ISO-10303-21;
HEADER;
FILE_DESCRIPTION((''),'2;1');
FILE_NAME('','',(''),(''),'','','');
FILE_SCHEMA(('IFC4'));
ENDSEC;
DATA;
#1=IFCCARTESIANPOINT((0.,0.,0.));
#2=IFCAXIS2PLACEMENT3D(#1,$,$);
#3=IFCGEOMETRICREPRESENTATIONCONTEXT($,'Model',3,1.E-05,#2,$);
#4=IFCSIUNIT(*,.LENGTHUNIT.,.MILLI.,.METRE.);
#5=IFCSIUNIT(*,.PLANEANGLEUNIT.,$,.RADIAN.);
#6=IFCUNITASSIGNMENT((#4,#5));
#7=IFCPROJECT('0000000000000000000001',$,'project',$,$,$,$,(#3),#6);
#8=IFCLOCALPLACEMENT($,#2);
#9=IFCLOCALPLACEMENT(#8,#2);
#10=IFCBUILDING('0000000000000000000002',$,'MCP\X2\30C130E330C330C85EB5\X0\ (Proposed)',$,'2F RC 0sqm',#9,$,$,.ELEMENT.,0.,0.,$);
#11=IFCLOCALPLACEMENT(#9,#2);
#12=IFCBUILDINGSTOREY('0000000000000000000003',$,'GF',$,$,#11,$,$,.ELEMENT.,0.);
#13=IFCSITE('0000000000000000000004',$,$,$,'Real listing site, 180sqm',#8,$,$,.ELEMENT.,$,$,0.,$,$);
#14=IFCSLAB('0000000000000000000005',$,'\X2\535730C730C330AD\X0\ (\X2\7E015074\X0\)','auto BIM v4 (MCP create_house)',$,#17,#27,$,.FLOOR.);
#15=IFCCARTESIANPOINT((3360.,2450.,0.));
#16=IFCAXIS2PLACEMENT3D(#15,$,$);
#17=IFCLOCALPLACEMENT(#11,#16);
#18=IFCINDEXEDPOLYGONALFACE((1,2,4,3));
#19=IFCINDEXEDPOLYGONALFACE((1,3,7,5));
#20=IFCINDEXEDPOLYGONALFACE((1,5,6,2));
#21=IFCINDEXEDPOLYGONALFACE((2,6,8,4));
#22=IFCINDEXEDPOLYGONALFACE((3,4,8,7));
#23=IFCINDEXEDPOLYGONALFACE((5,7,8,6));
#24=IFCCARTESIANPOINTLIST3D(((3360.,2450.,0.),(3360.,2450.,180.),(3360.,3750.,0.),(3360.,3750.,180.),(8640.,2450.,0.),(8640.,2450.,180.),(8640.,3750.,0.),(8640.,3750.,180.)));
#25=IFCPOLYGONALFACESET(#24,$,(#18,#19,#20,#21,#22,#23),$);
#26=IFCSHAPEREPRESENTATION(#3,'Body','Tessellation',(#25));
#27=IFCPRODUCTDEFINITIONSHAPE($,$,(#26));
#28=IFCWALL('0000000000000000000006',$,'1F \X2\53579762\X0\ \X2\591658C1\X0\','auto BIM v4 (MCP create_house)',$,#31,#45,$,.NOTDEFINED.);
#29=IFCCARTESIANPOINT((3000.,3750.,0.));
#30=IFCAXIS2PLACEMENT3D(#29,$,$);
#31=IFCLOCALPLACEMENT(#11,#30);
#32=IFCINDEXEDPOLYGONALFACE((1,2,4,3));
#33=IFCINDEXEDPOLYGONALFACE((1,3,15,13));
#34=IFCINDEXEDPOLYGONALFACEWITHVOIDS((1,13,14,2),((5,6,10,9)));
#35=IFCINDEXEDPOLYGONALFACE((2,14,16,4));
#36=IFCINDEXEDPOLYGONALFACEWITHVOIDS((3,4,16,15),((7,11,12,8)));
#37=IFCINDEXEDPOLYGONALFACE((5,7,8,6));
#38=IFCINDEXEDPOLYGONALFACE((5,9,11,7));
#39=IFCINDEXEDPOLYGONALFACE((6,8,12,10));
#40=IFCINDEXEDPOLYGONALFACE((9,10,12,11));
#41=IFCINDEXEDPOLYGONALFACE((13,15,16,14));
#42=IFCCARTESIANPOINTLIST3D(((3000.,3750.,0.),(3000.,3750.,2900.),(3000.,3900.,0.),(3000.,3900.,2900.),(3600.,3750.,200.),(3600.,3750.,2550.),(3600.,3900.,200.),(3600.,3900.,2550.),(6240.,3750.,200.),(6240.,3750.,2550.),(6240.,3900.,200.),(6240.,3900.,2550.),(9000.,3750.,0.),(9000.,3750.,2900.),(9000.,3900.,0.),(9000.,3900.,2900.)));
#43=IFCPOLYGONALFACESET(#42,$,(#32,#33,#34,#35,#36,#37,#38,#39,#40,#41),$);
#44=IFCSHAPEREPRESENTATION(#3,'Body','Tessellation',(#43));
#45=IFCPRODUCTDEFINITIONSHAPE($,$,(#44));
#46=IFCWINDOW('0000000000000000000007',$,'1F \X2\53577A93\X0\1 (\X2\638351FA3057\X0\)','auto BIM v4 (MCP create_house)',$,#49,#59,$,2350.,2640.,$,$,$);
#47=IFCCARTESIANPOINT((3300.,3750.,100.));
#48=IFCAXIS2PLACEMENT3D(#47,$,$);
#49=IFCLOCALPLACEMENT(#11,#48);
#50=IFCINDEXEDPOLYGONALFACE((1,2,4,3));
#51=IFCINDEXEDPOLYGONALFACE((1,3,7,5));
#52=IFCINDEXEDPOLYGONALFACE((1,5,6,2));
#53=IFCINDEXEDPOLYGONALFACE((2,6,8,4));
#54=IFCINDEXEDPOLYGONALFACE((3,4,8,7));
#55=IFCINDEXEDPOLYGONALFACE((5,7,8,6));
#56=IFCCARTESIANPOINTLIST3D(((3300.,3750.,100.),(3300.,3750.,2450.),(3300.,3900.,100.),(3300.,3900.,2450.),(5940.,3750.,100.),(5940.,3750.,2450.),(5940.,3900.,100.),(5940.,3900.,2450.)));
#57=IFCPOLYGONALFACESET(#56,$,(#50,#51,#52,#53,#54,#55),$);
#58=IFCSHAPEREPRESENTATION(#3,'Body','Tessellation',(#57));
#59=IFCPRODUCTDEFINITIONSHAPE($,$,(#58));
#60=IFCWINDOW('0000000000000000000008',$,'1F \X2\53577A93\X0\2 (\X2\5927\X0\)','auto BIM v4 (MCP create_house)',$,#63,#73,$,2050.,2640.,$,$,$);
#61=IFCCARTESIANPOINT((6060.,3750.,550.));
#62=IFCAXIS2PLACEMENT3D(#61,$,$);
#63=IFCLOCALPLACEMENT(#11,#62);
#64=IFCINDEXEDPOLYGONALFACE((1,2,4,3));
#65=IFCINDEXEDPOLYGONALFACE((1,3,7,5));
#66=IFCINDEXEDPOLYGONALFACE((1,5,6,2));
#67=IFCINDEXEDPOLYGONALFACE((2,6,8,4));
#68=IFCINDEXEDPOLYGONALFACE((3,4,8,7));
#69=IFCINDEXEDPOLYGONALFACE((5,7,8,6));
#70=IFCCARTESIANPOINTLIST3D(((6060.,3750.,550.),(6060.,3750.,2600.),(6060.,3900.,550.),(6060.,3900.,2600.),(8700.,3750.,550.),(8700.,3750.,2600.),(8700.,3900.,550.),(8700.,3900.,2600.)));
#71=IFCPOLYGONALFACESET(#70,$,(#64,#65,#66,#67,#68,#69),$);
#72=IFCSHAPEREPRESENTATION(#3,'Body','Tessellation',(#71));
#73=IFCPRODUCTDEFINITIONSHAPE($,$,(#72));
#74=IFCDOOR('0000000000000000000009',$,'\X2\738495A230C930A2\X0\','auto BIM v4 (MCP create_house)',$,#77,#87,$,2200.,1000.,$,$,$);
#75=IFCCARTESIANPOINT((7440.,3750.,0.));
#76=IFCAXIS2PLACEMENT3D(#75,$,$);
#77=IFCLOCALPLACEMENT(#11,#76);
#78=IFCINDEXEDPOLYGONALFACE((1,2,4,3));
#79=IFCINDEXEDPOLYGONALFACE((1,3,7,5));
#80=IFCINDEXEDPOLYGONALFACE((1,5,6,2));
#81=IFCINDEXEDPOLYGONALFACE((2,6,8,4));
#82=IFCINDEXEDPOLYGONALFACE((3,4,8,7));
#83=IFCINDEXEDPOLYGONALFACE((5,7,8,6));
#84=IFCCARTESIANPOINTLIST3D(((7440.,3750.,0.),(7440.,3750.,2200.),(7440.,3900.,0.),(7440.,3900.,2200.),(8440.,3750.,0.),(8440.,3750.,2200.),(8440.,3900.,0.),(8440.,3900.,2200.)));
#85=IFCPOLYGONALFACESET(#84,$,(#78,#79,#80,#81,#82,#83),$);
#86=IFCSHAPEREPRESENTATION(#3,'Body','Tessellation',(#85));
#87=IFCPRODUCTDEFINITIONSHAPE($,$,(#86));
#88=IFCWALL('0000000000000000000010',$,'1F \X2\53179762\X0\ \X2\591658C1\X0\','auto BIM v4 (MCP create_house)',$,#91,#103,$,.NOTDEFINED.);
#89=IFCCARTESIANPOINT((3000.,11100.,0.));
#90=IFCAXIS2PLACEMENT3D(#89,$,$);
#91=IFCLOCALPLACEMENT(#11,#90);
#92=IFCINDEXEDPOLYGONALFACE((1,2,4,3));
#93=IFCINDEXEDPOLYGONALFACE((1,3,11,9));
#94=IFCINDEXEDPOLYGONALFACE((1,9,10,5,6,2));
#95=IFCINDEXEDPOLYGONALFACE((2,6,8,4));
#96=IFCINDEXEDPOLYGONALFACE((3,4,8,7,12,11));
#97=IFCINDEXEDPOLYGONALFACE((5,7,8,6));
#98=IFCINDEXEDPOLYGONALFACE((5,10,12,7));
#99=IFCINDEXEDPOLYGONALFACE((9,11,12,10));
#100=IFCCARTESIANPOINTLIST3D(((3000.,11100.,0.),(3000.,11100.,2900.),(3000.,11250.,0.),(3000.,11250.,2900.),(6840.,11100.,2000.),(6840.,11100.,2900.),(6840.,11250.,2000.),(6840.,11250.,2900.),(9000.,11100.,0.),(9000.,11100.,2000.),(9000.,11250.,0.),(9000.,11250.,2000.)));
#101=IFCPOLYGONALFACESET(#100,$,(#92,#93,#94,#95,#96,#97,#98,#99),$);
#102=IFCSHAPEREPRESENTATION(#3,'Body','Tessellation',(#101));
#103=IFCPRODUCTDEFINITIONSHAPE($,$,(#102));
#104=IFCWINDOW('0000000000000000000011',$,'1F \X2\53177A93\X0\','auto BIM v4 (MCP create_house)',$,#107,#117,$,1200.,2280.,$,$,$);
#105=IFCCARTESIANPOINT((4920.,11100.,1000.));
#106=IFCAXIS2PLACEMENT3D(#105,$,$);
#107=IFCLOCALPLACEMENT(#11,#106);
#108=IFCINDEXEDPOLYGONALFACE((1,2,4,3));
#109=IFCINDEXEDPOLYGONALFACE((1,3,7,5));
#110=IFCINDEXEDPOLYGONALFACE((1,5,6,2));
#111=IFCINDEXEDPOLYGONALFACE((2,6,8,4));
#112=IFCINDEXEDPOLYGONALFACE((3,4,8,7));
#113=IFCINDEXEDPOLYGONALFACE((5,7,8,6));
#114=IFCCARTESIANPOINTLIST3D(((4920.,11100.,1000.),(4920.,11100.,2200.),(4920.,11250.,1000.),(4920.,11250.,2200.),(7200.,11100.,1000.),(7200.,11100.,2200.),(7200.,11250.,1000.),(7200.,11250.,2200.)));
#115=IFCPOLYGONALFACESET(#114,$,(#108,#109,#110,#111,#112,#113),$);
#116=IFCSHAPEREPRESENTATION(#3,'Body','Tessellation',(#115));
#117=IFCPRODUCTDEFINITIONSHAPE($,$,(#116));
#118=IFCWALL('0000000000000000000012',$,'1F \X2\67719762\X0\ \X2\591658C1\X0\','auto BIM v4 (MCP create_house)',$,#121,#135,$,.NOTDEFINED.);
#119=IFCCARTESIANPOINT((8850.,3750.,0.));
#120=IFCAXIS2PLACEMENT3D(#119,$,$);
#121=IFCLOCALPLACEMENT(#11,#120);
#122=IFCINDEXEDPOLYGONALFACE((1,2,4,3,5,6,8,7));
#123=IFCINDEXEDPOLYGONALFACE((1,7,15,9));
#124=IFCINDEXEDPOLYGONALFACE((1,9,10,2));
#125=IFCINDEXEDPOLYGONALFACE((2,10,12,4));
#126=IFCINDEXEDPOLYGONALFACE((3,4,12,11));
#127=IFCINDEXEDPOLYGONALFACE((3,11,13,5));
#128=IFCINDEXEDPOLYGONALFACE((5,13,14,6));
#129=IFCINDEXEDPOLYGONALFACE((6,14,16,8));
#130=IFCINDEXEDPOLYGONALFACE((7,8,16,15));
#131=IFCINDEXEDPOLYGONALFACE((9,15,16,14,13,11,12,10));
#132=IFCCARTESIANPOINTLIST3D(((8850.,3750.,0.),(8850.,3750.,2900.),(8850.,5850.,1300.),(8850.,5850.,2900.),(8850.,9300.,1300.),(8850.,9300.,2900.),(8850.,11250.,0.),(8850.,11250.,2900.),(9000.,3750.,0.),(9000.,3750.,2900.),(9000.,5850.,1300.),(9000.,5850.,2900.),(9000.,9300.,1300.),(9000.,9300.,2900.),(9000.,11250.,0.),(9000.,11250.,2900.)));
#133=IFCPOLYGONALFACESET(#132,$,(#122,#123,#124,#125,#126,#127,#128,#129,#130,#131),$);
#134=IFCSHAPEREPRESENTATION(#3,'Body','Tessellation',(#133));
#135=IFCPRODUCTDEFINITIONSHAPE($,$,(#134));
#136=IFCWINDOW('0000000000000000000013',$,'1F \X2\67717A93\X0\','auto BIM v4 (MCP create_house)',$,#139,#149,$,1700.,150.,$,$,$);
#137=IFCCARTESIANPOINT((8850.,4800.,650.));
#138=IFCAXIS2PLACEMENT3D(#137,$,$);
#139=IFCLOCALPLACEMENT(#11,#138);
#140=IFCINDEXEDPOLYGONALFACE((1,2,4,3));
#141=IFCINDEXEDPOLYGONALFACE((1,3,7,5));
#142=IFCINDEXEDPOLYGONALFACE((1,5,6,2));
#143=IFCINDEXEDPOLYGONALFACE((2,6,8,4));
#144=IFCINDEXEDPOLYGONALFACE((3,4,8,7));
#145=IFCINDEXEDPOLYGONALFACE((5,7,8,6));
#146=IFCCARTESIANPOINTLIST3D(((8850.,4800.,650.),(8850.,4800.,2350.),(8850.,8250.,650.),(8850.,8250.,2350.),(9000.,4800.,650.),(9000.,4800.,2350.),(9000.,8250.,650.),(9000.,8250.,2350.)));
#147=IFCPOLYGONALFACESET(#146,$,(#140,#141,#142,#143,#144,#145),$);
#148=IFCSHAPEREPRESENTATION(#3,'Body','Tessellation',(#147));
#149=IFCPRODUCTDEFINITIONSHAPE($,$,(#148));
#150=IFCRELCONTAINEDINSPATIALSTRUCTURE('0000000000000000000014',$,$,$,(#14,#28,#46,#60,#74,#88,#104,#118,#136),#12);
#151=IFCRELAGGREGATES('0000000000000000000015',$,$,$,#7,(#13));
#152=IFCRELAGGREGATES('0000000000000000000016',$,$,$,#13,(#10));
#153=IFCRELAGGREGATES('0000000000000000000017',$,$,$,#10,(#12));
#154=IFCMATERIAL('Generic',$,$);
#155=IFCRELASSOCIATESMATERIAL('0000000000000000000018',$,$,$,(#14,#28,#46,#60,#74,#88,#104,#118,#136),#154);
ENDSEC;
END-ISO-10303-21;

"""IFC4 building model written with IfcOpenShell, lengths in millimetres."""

from ifc_helpers import new_model, si_unit, frame, frame_2d, origin, place, context, project, spatial, rectangle, extrude, material, element, fill, save


model = new_model("IFC4")

# Units and contexts
model_context = context("Model", 3, precision=1e-05, world=origin())
ifc_project = project(units=[si_unit("LENGTHUNIT", "METRE", prefix="MILLI"), si_unit("PLANEANGLEUNIT", "RADIAN")], contexts=[model_context])

# Site, building, storey
site_placement = place(None, origin())
site = spatial("IfcSite", under=ifc_project, at=site_placement, ObjectType="Real listing site, 180sqm", CompositionType="ELEMENT", RefElevation=0.0)
building_placement = place(site_placement, origin())
building = spatial("IfcBuilding", under=site, at=building_placement, Name="MCPチャット庵 (Proposed)", ObjectType="2F RC 0sqm", CompositionType="ELEMENT", ElevationOfRefHeight=0.0, ElevationOfTerrain=0.0)
storey_placement = place(building_placement, origin())
storey = spatial("IfcBuildingStorey", under=building, at=storey_placement, Name="GF", CompositionType="ELEMENT", Elevation=0.0)

# Slab
ifc_material = material(Name="Generic")
slab_1_placement = place(storey_placement, frame((3360.0, 2450.0, 0.0)))
element("IfcSlab", 1, at=slab_1_placement, inside=storey, material=ifc_material, Name="南デッキ (縁側)", Description="auto BIM v4 (MCP create_house)", PredefinedType="FLOOR", context=model_context, shape_type="SweptSolid", body=[
    extrude(rectangle(XDim=5280.0, YDim=1300.0, at=frame_2d((2640.0, 650.0))), frame((3360.0, 2450.0, 0.0)), (0.0, 0.0, 1.0), 180.0),
])

# Wall, openings, windows, door
wall_1_placement = place(storey_placement, frame((3000.0, 3750.0, 0.0)))
wall_1 = element("IfcWall", 2, at=wall_1_placement, inside=storey, material=ifc_material, Name="1F 南面 外壁", Description="auto BIM v4 (MCP create_house)", PredefinedType="NOTDEFINED", context=model_context, shape_type="SweptSolid", body=[
    extrude(rectangle(XDim=6000.0, YDim=150.0, at=frame_2d((3000.0, 75.0))), frame((3000.0, 3750.0, 0.0)), (0.0, 0.0, 1.0), 2900.0),
])
opening_1_placement = place(storey_placement, frame((3300.0, 3750.0, 100.0)))
opening_1 = element("IfcOpeningElement", 3, at=opening_1_placement, cuts=wall_1, PredefinedType="NOTDEFINED", context=model_context, shape_type="SweptSolid", body=[
    extrude(rectangle(XDim=2640.0, YDim=150.0, at=frame_2d((1320.0, 75.0))), frame((3300.0, 3750.0, 100.0)), (0.0, 0.0, 1.0), 2350.0),
])
opening_2_placement = place(storey_placement, frame((6060.0, 3750.0, 550.0)))
opening_2 = element("IfcOpeningElement", 4, at=opening_2_placement, cuts=wall_1, PredefinedType="NOTDEFINED", context=model_context, shape_type="SweptSolid", body=[
    extrude(rectangle(XDim=2640.0, YDim=150.0, at=frame_2d((1320.0, 75.0))), frame((6060.0, 3750.0, 550.0)), (0.0, 0.0, 1.0), 2050.0),
])
opening_3_placement = place(storey_placement, frame((7440.0, 3750.0, 0.0)))
opening_3 = element("IfcOpeningElement", 5, at=opening_3_placement, cuts=wall_1, PredefinedType="NOTDEFINED", context=model_context, shape_type="SweptSolid", body=[
    extrude(rectangle(XDim=1000.0, YDim=150.0, at=frame_2d((500.0, 75.0))), frame((7440.0, 3750.0, 0.0)), (0.0, 0.0, 1.0), 2200.0),
])
window_1_placement = place(storey_placement, frame((3300.0, 3750.0, 100.0)))
window_1 = element("IfcWindow", 6, at=window_1_placement, inside=storey, material=ifc_material, Name="1F 南窓1 (掃出し)", Description="auto BIM v4 (MCP create_house)", OverallHeight=2350.0, OverallWidth=2640.0, context=model_context, shape_type="SweptSolid", body=[
    extrude(rectangle(XDim=2640.0, YDim=150.0, at=frame_2d((1320.0, 75.0))), frame((3300.0, 3750.0, 100.0)), (0.0, 0.0, 1.0), 2350.0),
])
fill(opening_1, window_1)
window_2_placement = place(storey_placement, frame((6060.0, 3750.0, 550.0)))
window_2 = element("IfcWindow", 7, at=window_2_placement, inside=storey, material=ifc_material, Name="1F 南窓2 (大)", Description="auto BIM v4 (MCP create_house)", OverallHeight=2050.0, OverallWidth=2640.0, context=model_context, shape_type="SweptSolid", body=[
    extrude(rectangle(XDim=2640.0, YDim=150.0, at=frame_2d((1320.0, 75.0))), frame((6060.0, 3750.0, 550.0)), (0.0, 0.0, 1.0), 2050.0),
])
fill(opening_2, window_2)
door_1_placement = place(storey_placement, frame((7440.0, 3750.0, 0.0)))
door_1 = element("IfcDoor", 8, at=door_1_placement, inside=storey, material=ifc_material, Name="玄関ドア", Description="auto BIM v4 (MCP create_house)", OverallHeight=2200.0, OverallWidth=1000.0, context=model_context, shape_type="SweptSolid", body=[
    extrude(rectangle(XDim=1000.0, YDim=150.0, at=frame_2d((500.0, 75.0))), frame((7440.0, 3750.0, 0.0)), (0.0, 0.0, 1.0), 2200.0),
])
fill(opening_3, door_1)

# Walls, openings, windows
wall_2_placement = place(storey_placement, frame((3000.0, 11100.0, 0.0)))
wall_2 = element("IfcWall", 9, at=wall_2_placement, inside=storey, material=ifc_material, Name="1F 北面 外壁", Description="auto BIM v4 (MCP create_house)", PredefinedType="NOTDEFINED", context=model_context, shape_type="SweptSolid", body=[
    extrude(rectangle(XDim=6000.0, YDim=150.0, at=frame_2d((3000.0, 75.0))), frame((3000.0, 11100.0, 0.0)), (0.0, 0.0, 1.0), 2900.0),
])
opening_4_placement = place(storey_placement, frame((4920.0, 11100.0, 1000.0)))
opening_4 = element("IfcOpeningElement", 10, at=opening_4_placement, cuts=wall_2, PredefinedType="NOTDEFINED", context=model_context, shape_type="SweptSolid", body=[
    extrude(rectangle(XDim=2280.0, YDim=150.0, at=frame_2d((1140.0, 75.0))), frame((4920.0, 11100.0, 1000.0)), (0.0, 0.0, 1.0), 1200.0),
])
window_3_placement = place(storey_placement, frame((4920.0, 11100.0, 1000.0)))
window_3 = element("IfcWindow", 11, at=window_3_placement, inside=storey, material=ifc_material, Name="1F 北窓", Description="auto BIM v4 (MCP create_house)", OverallHeight=1200.0, OverallWidth=2280.0, context=model_context, shape_type="SweptSolid", body=[
    extrude(rectangle(XDim=2280.0, YDim=150.0, at=frame_2d((1140.0, 75.0))), frame((4920.0, 11100.0, 1000.0)), (0.0, 0.0, 1.0), 1200.0),
])
fill(opening_4, window_3)
wall_3_placement = place(storey_placement, frame((8850.0, 3750.0, 0.0)))
wall_3 = element("IfcWall", 12, at=wall_3_placement, inside=storey, material=ifc_material, Name="1F 東面 外壁", Description="auto BIM v4 (MCP create_house)", PredefinedType="NOTDEFINED", context=model_context, shape_type="SweptSolid", body=[
    extrude(rectangle(XDim=150.0, YDim=7500.0, at=frame_2d((75.0, 3750.0))), frame((8850.0, 3750.0, 0.0)), (0.0, 0.0, 1.0), 2900.0),
])
opening_5_placement = place(storey_placement, frame((8850.0, 4800.0, 650.0)))
opening_5 = element("IfcOpeningElement", 13, at=opening_5_placement, cuts=wall_3, PredefinedType="NOTDEFINED", context=model_context, shape_type="SweptSolid", body=[
    extrude(rectangle(XDim=150.0, YDim=3450.0, at=frame_2d((75.0, 1725.0))), frame((8850.0, 4800.0, 650.0)), (0.0, 0.0, 1.0), 1700.0),
])
window_4_placement = place(storey_placement, frame((8850.0, 4800.0, 650.0)))
window_4 = element("IfcWindow", 14, at=window_4_placement, inside=storey, material=ifc_material, Name="1F 東窓", Description="auto BIM v4 (MCP create_house)", OverallHeight=1700.0, OverallWidth=150.0, context=model_context, shape_type="SweptSolid", body=[
    extrude(rectangle(XDim=150.0, YDim=3450.0, at=frame_2d((75.0, 1725.0))), frame((8850.0, 4800.0, 650.0)), (0.0, 0.0, 1.0), 1700.0),
])
fill(opening_5, window_4)

save(model, "model.ifc")
